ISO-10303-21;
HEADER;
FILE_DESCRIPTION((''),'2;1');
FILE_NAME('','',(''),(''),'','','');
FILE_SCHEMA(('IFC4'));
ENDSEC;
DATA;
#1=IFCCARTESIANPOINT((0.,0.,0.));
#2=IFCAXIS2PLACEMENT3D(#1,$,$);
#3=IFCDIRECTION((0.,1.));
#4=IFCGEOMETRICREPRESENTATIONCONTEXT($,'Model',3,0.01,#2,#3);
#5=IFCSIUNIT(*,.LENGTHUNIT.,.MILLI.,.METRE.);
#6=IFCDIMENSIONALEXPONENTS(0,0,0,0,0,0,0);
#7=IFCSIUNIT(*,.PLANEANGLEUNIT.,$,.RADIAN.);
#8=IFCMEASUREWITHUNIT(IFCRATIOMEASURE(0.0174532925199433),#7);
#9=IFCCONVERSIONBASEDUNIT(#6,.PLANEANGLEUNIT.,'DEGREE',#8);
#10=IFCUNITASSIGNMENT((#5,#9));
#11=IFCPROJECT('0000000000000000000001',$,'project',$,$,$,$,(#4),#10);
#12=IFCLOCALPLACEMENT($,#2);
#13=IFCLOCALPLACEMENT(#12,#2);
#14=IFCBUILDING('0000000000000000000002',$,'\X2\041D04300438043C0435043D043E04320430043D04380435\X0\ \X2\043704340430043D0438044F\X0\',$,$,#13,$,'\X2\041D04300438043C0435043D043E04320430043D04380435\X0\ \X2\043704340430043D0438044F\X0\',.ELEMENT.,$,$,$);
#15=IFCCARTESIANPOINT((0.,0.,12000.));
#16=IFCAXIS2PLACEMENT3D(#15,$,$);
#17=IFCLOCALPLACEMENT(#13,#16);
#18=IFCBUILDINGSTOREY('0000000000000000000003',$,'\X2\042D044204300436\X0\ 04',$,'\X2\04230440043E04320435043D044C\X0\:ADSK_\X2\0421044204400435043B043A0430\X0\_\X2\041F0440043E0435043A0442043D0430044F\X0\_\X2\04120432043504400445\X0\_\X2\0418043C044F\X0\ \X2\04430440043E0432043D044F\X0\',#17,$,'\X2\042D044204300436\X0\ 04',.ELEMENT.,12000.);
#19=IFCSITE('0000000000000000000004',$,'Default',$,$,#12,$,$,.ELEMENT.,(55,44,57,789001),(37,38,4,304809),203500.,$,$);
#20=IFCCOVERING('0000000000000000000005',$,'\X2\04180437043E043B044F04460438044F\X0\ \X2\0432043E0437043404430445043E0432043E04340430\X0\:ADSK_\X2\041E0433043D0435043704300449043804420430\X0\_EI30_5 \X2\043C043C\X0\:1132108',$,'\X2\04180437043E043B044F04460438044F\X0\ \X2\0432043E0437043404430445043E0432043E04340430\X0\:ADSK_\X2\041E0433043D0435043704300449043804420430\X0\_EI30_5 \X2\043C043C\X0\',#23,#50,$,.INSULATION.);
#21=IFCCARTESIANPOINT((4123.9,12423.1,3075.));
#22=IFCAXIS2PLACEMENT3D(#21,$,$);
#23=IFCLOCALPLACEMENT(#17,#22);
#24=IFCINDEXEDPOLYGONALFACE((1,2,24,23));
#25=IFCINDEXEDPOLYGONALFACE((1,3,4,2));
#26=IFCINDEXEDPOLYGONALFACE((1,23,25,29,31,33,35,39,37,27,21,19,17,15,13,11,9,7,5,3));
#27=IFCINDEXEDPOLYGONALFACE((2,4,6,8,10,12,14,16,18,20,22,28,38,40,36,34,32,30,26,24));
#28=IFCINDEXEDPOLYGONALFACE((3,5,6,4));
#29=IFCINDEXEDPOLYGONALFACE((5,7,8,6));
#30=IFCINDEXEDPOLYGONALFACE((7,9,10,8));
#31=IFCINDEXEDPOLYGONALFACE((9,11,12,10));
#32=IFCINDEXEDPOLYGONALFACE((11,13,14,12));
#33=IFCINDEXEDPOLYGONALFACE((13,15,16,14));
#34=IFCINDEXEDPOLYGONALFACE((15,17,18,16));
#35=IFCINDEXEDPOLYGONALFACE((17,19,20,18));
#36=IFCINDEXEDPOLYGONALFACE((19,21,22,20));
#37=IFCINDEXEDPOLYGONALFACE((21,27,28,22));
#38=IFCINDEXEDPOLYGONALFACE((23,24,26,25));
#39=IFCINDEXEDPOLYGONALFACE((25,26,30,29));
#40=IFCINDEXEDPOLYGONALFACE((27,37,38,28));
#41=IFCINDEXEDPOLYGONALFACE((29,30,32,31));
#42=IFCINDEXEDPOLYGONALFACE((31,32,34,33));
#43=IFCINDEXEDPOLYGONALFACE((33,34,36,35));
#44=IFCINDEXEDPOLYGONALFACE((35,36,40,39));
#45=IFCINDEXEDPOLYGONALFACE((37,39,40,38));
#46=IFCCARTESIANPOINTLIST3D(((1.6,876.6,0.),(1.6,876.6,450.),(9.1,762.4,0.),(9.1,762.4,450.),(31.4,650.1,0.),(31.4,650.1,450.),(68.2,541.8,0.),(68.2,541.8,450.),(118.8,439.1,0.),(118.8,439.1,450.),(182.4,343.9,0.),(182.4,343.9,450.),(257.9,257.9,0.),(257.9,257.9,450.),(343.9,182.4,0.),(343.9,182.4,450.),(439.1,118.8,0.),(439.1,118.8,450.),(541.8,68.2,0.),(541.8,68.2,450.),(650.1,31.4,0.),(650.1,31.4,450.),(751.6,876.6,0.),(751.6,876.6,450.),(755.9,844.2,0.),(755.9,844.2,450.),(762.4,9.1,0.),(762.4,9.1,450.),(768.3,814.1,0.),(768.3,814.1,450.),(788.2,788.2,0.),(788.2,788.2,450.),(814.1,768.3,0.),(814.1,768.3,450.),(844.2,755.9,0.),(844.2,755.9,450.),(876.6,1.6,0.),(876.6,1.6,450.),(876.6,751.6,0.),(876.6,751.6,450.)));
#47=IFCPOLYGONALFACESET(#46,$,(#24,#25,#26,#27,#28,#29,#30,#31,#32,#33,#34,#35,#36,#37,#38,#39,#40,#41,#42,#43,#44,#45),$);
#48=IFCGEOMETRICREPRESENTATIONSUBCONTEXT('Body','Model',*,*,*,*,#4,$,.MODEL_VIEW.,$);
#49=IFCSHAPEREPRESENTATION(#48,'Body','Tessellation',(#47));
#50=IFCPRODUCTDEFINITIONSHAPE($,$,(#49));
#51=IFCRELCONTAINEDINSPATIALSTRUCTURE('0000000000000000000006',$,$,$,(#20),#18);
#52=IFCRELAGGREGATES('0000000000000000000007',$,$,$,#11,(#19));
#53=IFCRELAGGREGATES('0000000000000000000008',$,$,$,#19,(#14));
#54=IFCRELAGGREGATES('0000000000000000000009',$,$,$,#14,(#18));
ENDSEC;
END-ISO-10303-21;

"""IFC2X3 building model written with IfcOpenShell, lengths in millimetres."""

from ifc_helpers import new_model, entity, si_unit, converted_unit, direction, frame, frame_2d, origin, place, context, subcontext, project, spatial, polyline, circle_curve, parameter, trimmed, segment, composite_curve, outline, extrude, element, save


model = new_model("IFC2X3")

# Units and contexts
model_context = context("Model", 3, precision=0.01, world=origin(), true_north=direction((0.0, 1.0)))
body_context = subcontext(model_context, "Body", "Model", "MODEL_VIEW")
ifc_project = project(units=[si_unit("LENGTHUNIT", "METRE", prefix="MILLI"), converted_unit("PLANEANGLEUNIT", "DEGREE", entity("IfcRatioMeasure", 0.0174532925199433), si_unit("PLANEANGLEUNIT", "RADIAN"), dimensions=[0, 0, 0, 0, 0, 0, 0])], contexts=[model_context])

# Site, building, storey
site_placement = place(None, origin())
site = spatial("IfcSite", under=ifc_project, at=site_placement, Name="Default", CompositionType="ELEMENT", RefLatitude=(55, 44, 57, 789001), RefLongitude=(37, 38, 4, 304809), RefElevation=203500.0)
building_placement = place(site_placement, origin())
building = spatial("IfcBuilding", under=site, at=building_placement, Name="Наименование здания", LongName="Наименование здания", CompositionType="ELEMENT")
storey_placement = place(building_placement, frame((0.0, 0.0, 12000.0)))
storey = spatial("IfcBuildingStorey", under=building, at=storey_placement, Name="Этаж 04", ObjectType="Уровень:ADSK_Стрелка_Проектная_Вверх_Имя уровня", LongName="Этаж 04", CompositionType="ELEMENT", Elevation=12000.0)

# Covering
covering_1_placement = place(storey_placement, frame((4123.9, 12423.1, 3075.0)))
element("IfcCovering", 1, at=covering_1_placement, inside=storey, Name="Изоляция воздуховода:ADSK_Огнезащита_EI30_5 мм:1132108", ObjectType="Изоляция воздуховода:ADSK_Огнезащита_EI30_5 мм", PredefinedType="INSULATION", context=body_context, shape_type="SweptSolid", body=[
    extrude(outline(composite_curve([segment(polyline([(-250.0, 125.0), (-250.0, -625.0)]), True, "CONTINUOUS"), segment(trimmed(circle_curve(frame_2d((-250.0, 250.0), x_axis=(1.0, 0.0)), 875.0), [parameter(270.0)], [parameter(0.0)], True, "PARAMETER"), True, "CONTINUOUS"), segment(polyline([(625.0, 250.0), (-125.0, 250.0)]), True, "CONTINUOUS"), segment(trimmed(circle_curve(frame_2d((-250.0, 250.0), x_axis=(1.0, 0.0)), 125.0), [parameter(270.0)], [parameter(360.0)], True, "PARAMETER"), False, "CONTINUOUS")], self_intersect=False)), frame((626.6, 626.6, 0.0), z_axis=(0.0, 0.0, -1.0), x_axis=(-1.0, 0.0, 0.0)), (0.0, 0.0, -1.0), 450.0),
])

save(model, "model.ifc")
